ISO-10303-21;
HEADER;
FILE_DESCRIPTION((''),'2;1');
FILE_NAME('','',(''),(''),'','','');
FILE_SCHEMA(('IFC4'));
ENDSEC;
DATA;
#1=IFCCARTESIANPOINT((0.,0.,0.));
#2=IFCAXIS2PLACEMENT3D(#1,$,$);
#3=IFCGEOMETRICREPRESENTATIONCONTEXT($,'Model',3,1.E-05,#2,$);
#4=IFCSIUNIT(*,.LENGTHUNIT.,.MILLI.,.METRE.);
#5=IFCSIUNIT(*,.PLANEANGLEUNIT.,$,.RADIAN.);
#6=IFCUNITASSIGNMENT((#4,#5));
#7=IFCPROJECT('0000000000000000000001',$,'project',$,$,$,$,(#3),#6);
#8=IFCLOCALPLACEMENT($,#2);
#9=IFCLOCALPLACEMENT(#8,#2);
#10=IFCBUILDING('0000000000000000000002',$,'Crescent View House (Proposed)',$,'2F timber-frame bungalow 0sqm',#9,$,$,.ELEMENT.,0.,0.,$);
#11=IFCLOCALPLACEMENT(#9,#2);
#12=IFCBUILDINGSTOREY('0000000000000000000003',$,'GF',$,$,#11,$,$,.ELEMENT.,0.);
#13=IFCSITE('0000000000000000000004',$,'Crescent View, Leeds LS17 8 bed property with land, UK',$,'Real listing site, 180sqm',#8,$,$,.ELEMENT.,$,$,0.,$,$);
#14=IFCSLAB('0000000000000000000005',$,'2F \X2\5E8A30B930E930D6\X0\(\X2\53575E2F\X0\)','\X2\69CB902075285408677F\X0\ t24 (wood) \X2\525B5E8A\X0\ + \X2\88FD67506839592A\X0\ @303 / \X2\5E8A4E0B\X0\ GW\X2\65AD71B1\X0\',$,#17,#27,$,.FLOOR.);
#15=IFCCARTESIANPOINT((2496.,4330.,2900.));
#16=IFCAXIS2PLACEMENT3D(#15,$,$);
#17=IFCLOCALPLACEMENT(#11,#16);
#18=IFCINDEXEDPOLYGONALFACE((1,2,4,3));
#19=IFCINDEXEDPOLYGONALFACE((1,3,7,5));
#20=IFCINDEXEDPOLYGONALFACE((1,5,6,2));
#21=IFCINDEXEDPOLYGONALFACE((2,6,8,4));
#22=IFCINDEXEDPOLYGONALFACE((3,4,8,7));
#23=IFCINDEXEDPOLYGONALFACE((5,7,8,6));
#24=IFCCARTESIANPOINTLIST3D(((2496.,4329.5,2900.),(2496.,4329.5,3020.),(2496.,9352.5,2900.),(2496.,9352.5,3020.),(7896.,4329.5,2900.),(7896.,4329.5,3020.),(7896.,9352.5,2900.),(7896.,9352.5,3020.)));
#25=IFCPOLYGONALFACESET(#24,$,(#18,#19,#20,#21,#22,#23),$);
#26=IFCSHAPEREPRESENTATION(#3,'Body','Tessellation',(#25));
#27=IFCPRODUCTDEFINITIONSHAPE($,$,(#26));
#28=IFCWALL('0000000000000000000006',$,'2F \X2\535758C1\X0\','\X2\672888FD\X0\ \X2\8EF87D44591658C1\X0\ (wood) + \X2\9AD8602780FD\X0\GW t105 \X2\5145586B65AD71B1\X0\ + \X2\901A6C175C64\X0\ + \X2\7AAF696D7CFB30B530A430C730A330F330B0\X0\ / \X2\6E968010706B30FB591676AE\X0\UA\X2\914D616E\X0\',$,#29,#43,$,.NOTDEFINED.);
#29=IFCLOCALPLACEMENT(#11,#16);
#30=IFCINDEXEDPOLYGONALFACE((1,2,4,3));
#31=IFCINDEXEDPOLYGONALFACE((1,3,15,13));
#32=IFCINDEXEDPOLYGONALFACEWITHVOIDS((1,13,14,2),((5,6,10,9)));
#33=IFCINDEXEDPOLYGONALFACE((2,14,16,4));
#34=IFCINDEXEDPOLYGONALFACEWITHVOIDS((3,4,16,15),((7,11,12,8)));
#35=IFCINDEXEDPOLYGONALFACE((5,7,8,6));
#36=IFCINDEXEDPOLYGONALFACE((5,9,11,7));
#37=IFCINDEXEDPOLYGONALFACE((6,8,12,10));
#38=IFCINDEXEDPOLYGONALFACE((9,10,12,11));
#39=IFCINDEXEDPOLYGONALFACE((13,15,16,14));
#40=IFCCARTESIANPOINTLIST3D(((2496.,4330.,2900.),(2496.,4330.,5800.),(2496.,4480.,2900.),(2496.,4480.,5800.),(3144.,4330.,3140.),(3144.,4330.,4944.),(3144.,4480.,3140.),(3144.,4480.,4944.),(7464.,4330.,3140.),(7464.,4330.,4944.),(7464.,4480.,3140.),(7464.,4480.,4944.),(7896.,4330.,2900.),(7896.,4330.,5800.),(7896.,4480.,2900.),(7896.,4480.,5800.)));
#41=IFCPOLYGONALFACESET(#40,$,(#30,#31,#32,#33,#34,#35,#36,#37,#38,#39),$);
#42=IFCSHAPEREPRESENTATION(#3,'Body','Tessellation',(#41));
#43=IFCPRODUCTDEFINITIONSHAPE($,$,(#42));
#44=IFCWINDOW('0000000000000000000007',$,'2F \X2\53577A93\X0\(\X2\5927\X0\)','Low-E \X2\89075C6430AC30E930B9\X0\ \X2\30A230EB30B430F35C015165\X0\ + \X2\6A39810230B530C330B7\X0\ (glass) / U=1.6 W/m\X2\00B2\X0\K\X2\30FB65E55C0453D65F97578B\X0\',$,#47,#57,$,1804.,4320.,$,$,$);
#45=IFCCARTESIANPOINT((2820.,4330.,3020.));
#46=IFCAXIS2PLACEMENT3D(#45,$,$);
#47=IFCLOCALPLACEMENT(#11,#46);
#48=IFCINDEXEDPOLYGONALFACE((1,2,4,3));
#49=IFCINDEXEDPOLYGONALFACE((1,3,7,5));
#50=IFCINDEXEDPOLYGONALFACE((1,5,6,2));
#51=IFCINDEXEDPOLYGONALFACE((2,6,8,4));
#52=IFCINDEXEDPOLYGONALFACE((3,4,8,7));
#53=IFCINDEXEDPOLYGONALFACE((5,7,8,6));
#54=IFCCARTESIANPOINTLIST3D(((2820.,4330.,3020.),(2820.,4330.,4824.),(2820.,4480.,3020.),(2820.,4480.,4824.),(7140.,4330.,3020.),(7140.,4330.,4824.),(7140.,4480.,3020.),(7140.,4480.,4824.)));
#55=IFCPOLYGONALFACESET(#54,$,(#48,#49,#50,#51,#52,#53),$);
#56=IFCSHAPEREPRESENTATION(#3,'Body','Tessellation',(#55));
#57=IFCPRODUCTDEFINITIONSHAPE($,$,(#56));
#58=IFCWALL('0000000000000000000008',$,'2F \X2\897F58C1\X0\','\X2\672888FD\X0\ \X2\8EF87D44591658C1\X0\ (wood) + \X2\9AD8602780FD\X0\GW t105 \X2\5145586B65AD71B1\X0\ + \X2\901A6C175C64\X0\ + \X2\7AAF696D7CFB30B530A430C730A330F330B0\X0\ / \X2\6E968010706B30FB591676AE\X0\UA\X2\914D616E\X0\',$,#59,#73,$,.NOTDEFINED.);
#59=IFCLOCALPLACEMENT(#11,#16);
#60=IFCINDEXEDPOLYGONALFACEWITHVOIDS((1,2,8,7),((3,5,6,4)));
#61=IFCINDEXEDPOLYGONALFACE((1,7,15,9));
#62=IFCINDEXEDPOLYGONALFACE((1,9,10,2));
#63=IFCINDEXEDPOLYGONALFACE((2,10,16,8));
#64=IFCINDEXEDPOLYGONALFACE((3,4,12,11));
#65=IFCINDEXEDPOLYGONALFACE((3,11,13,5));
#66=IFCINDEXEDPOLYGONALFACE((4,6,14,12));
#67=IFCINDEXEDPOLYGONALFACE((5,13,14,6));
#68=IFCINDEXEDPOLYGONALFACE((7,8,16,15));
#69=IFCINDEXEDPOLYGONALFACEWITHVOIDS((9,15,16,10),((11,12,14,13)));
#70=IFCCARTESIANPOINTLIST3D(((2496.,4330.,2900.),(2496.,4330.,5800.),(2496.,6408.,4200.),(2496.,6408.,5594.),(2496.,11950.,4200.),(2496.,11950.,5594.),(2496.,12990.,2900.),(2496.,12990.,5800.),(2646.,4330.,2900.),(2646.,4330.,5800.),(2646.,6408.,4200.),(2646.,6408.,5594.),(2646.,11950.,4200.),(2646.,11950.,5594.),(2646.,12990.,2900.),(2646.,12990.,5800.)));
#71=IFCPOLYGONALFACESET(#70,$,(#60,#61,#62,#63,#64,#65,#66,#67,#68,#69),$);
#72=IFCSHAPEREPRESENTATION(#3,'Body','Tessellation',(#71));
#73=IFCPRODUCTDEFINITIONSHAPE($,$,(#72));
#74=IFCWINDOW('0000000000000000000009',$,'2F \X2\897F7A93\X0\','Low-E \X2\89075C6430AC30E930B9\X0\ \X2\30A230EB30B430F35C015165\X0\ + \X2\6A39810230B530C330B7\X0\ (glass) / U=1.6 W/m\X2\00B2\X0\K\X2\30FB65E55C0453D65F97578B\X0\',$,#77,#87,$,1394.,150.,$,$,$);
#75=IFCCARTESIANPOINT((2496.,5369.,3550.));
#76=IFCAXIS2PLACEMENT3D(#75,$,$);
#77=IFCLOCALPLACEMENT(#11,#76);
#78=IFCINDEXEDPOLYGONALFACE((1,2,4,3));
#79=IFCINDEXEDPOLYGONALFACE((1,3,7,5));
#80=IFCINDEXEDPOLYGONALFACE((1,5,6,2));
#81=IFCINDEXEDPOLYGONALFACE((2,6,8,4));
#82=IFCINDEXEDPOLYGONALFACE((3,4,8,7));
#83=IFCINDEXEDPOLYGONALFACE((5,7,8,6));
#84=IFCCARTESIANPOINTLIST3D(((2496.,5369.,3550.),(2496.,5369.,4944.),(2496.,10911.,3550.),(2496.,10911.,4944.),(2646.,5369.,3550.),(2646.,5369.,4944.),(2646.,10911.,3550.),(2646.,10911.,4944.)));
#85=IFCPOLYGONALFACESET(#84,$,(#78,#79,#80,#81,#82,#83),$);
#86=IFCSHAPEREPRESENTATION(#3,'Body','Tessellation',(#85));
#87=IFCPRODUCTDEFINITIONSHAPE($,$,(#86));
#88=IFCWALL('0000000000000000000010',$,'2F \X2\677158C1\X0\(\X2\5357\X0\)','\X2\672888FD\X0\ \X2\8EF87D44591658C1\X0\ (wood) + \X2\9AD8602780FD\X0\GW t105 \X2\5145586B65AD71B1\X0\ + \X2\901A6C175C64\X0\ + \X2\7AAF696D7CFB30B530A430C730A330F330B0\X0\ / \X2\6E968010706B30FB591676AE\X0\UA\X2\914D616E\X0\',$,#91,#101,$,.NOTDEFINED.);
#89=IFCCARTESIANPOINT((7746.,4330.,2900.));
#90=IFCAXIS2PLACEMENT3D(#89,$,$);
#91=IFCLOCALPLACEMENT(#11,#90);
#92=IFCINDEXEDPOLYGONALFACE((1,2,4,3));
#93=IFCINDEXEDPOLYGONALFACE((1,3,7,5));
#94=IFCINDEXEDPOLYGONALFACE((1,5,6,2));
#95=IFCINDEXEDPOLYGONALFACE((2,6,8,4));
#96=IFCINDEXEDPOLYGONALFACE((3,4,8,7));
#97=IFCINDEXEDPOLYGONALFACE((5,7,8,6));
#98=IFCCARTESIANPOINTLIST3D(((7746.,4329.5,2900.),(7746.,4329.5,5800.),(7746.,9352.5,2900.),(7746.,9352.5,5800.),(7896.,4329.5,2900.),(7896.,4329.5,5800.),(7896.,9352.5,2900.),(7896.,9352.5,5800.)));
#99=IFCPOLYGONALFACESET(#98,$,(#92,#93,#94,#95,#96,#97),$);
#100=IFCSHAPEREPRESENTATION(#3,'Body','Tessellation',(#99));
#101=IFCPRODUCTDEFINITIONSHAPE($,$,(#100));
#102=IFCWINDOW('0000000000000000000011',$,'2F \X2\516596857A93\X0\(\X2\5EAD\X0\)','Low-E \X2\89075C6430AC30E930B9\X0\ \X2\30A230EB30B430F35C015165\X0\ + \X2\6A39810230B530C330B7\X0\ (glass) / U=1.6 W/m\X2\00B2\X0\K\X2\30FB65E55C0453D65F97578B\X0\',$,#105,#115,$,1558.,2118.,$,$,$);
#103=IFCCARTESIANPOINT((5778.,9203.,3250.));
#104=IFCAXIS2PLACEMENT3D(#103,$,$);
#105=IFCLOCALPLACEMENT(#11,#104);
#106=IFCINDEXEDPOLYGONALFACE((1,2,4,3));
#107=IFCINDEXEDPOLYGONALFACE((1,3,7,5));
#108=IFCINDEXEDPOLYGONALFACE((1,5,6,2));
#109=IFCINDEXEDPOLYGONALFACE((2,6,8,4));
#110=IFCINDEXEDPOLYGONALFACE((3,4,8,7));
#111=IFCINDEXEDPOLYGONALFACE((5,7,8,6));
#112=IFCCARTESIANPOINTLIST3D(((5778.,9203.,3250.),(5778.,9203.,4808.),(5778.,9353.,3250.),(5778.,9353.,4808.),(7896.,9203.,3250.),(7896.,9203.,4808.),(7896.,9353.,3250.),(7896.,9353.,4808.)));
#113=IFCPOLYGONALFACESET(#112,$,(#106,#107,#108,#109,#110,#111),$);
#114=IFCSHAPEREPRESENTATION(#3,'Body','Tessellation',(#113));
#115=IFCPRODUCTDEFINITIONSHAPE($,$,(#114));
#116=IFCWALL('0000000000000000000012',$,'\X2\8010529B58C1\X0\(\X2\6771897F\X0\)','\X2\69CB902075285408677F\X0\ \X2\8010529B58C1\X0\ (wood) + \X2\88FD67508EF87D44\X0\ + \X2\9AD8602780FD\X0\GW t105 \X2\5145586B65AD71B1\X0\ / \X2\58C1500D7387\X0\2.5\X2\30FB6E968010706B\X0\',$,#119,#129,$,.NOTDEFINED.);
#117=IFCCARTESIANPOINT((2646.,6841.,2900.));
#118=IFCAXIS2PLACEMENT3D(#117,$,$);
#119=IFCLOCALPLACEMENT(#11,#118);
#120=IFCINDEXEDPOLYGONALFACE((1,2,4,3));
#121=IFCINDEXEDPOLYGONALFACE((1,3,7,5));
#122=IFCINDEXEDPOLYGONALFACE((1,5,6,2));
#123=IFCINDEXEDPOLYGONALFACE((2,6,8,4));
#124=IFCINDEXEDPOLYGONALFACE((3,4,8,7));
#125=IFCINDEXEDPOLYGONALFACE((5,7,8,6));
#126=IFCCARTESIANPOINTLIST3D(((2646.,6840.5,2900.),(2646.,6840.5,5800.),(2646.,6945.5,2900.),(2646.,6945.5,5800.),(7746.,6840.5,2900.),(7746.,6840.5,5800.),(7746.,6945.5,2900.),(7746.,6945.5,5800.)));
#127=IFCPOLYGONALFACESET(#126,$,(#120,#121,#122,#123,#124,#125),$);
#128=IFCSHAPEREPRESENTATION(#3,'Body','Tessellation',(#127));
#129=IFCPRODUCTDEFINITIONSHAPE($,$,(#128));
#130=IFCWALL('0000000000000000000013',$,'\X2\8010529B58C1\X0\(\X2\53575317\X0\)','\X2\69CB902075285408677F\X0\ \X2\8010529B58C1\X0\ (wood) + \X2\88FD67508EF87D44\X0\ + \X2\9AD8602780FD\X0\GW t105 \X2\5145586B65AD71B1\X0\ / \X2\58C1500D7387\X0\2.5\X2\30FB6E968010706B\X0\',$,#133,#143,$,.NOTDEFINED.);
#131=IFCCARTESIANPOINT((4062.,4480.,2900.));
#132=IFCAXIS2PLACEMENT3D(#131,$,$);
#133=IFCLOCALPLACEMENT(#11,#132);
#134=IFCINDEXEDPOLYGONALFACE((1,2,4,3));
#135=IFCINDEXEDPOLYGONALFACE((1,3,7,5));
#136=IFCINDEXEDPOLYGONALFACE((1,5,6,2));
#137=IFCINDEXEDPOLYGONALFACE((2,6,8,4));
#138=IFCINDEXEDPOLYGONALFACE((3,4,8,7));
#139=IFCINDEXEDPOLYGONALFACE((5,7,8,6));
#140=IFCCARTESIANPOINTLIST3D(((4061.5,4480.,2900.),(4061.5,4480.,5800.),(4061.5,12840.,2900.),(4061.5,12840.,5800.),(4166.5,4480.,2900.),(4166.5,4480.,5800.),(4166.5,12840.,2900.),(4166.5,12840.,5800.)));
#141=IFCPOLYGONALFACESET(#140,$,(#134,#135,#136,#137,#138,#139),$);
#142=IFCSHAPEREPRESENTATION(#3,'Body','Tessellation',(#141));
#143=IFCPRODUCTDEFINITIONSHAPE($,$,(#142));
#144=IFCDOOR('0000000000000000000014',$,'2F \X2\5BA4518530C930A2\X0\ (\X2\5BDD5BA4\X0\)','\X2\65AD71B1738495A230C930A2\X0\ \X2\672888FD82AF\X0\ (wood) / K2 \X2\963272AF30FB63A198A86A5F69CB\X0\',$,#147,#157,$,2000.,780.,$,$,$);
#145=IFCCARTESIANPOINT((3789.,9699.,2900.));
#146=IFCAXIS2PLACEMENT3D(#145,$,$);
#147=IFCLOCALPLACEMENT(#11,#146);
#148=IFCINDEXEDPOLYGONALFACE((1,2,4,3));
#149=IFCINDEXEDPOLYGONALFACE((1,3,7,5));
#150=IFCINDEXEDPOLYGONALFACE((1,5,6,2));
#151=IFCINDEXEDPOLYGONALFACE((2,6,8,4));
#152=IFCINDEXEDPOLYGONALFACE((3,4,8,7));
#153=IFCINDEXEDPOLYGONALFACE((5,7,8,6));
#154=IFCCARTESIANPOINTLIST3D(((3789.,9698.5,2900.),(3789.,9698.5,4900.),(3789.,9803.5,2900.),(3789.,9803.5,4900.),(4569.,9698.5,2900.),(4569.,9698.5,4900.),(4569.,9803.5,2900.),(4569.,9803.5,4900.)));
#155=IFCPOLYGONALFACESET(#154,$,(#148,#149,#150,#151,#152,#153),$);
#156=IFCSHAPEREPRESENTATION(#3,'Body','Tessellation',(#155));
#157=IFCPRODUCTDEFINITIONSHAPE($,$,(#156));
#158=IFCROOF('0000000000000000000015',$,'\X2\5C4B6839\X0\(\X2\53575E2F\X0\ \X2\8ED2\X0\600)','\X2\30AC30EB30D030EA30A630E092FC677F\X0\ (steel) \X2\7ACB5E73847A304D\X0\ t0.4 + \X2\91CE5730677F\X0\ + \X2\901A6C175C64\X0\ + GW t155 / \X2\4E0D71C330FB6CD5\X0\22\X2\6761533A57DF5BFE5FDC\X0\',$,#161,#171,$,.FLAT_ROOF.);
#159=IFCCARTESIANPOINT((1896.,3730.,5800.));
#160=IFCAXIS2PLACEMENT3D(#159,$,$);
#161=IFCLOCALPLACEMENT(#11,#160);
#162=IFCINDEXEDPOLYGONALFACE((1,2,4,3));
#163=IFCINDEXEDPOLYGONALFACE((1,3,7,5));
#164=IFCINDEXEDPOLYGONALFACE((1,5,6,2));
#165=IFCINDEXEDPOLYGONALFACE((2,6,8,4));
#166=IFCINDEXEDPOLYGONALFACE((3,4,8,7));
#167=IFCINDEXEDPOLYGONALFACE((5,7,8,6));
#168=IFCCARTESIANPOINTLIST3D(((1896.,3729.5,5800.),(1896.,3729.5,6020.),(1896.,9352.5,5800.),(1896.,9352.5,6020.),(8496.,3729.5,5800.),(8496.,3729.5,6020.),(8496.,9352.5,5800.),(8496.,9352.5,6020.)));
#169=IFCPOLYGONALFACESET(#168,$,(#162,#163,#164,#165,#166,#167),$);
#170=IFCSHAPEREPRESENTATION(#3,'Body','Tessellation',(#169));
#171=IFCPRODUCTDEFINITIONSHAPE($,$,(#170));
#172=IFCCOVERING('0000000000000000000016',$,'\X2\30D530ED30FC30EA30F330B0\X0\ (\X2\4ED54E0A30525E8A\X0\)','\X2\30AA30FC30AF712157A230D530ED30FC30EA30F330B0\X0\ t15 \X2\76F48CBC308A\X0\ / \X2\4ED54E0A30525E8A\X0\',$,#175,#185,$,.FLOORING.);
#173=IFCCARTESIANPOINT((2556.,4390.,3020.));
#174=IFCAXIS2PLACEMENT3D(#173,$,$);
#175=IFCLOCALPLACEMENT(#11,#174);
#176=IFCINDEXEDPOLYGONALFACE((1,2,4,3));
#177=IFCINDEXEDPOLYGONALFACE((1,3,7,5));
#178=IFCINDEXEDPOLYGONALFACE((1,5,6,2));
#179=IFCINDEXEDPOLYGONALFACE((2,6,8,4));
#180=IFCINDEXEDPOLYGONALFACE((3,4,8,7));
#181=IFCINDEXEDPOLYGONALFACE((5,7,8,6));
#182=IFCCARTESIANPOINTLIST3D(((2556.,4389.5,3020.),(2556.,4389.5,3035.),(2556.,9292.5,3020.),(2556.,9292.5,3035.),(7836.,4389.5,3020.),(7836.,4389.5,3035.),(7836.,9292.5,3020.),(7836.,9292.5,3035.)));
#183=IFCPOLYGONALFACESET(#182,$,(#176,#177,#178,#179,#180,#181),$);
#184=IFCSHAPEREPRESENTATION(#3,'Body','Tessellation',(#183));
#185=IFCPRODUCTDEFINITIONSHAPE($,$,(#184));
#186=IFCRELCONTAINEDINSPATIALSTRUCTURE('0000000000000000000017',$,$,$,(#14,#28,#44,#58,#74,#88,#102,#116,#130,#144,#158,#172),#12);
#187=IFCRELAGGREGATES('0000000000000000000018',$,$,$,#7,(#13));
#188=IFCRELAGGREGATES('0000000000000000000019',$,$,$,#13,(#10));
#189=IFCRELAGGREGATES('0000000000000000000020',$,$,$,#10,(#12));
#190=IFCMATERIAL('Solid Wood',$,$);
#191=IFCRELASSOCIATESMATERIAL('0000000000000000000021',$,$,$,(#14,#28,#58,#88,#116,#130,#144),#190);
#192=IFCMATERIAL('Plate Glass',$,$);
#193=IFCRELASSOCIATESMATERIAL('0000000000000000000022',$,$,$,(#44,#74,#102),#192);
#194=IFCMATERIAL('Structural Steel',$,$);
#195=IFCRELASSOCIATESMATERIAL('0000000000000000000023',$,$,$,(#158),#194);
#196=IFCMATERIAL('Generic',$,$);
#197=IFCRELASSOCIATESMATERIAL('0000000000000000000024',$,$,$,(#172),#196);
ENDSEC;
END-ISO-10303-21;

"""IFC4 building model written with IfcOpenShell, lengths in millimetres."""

from ifc_helpers import new_model, si_unit, frame, frame_2d, origin, place, context, project, spatial, rectangle, extrude, material, element, fill, save


model = new_model("IFC4")

# Units and contexts
model_context = context("Model", 3, precision=1e-05, world=origin())
ifc_project = project(units=[si_unit("LENGTHUNIT", "METRE", prefix="MILLI"), si_unit("PLANEANGLEUNIT", "RADIAN")], contexts=[model_context])

# Site, building, storey
site_placement = place(None, origin())
site = spatial("IfcSite", under=ifc_project, at=site_placement, Name="Crescent View, Leeds LS17 8 bed property with land, UK", ObjectType="Real listing site, 180sqm", CompositionType="ELEMENT", RefElevation=0.0)
building_placement = place(site_placement, origin())
building = spatial("IfcBuilding", under=site, at=building_placement, Name="Crescent View House (Proposed)", ObjectType="2F timber-frame bungalow 0sqm", CompositionType="ELEMENT", ElevationOfRefHeight=0.0, ElevationOfTerrain=0.0)
storey_placement = place(building_placement, origin())
storey = spatial("IfcBuildingStorey", under=building, at=storey_placement, Name="GF", CompositionType="ELEMENT", Elevation=0.0)

# Slab
ifc_material_1 = material(Name="Solid Wood")
slab_placement = place(storey_placement, frame((2496.0, 4330.0, 2900.0)))
element("IfcSlab", 1, at=slab_placement, inside=storey, material=ifc_material_1, Name="2F 床スラブ(南帯)", Description="構造用合板 t24 (wood) 剛床 + 製材根太 @303 / 床下 GW断熱", PredefinedType="FLOOR", context=model_context, shape_type="SweptSolid", body=[
    extrude(rectangle(XDim=5400.0, YDim=5023.0, at=frame_2d((2700.0, 2511.0))), frame((2496.0, 4330.0, 2900.0)), (0.0, 0.0, 1.0), 120.0),
])

# Walls, openings, windows
wall_1_placement = place(storey_placement, frame((2496.0, 4330.0, 2900.0)))
wall_1 = element("IfcWall", 2, at=wall_1_placement, inside=storey, material=ifc_material_1, Name="2F 南壁", Description="木製 軸組外壁 (wood) + 高性能GW t105 充填断熱 + 通気層 + 窯業系サイディング / 準耐火・外皮UA配慮", PredefinedType="NOTDEFINED", context=model_context, shape_type="SweptSolid", body=[
    extrude(rectangle(XDim=5400.0, YDim=150.0, at=frame_2d((2700.0, 75.0))), frame((2496.0, 4330.0, 2900.0)), (0.0, 0.0, 1.0), 2900.0),
])
opening_1_placement = place(storey_placement, frame((2820.0, 4330.0, 3020.0)))
opening_1 = element("IfcOpeningElement", 3, at=opening_1_placement, cuts=wall_1, PredefinedType="NOTDEFINED", context=model_context, shape_type="SweptSolid", body=[
    extrude(rectangle(XDim=4320.0, YDim=150.0, at=frame_2d((2160.0, 75.0))), frame((2820.0, 4330.0, 3020.0)), (0.0, 0.0, 1.0), 1804.0),
])
ifc_material_2 = material(Name="Plate Glass")
window_1_placement = place(storey_placement, frame((2820.0, 4330.0, 3020.0)))
window_1 = element("IfcWindow", 4, at=window_1_placement, inside=storey, material=ifc_material_2, Name="2F 南窓(大)", Description="Low-E 複層ガラス アルゴン封入 + 樹脂サッシ (glass) / U=1.6 W/m²K・日射取得型", OverallHeight=1804.0, OverallWidth=4320.0, context=model_context, shape_type="SweptSolid", body=[
    extrude(rectangle(XDim=4320.0, YDim=150.0, at=frame_2d((2160.0, 75.0))), frame((2820.0, 4330.0, 3020.0)), (0.0, 0.0, 1.0), 1804.0),
])
fill(opening_1, window_1)
wall_2_placement = place(storey_placement, frame((2496.0, 4330.0, 2900.0)))
wall_2 = element("IfcWall", 5, at=wall_2_placement, inside=storey, material=ifc_material_1, Name="2F 西壁", Description="木製 軸組外壁 (wood) + 高性能GW t105 充填断熱 + 通気層 + 窯業系サイディング / 準耐火・外皮UA配慮", PredefinedType="NOTDEFINED", context=model_context, shape_type="SweptSolid", body=[
    extrude(rectangle(XDim=150.0, YDim=8660.0, at=frame_2d((75.0, 4330.0))), frame((2496.0, 4330.0, 2900.0)), (0.0, 0.0, 1.0), 2900.0),
])
opening_2_placement = place(storey_placement, frame((2496.0, 5369.0, 3550.0)))
opening_2 = element("IfcOpeningElement", 6, at=opening_2_placement, cuts=wall_2, PredefinedType="NOTDEFINED", context=model_context, shape_type="SweptSolid", body=[
    extrude(rectangle(XDim=150.0, YDim=5542.0, at=frame_2d((75.0, 2771.0))), frame((2496.0, 5369.0, 3550.0)), (0.0, 0.0, 1.0), 1394.0),
])
window_2_placement = place(storey_placement, frame((2496.0, 5369.0, 3550.0)))
window_2 = element("IfcWindow", 7, at=window_2_placement, inside=storey, material=ifc_material_2, Name="2F 西窓", Description="Low-E 複層ガラス アルゴン封入 + 樹脂サッシ (glass) / U=1.6 W/m²K・日射取得型", OverallHeight=1394.0, OverallWidth=150.0, context=model_context, shape_type="SweptSolid", body=[
    extrude(rectangle(XDim=150.0, YDim=5542.0, at=frame_2d((75.0, 2771.0))), frame((2496.0, 5369.0, 3550.0)), (0.0, 0.0, 1.0), 1394.0),
])
fill(opening_2, window_2)
wall_3_placement = place(storey_placement, frame((7746.0, 4330.0, 2900.0)))
wall_3 = element("IfcWall", 8, at=wall_3_placement, inside=storey, material=ifc_material_1, Name="2F 東壁(南)", Description="木製 軸組外壁 (wood) + 高性能GW t105 充填断熱 + 通気層 + 窯業系サイディング / 準耐火・外皮UA配慮", PredefinedType="NOTDEFINED", context=model_context, shape_type="SweptSolid", body=[
    extrude(rectangle(XDim=150.0, YDim=5023.0, at=frame_2d((75.0, 2511.0))), frame((7746.0, 4330.0, 2900.0)), (0.0, 0.0, 1.0), 2900.0),
])
opening_3_placement = place(storey_placement, frame((5778.0, 9203.0, 3250.0)))
opening_3 = element("IfcOpeningElement", 9, at=opening_3_placement, cuts=wall_3, PredefinedType="NOTDEFINED", context=model_context, shape_type="SweptSolid", body=[
    extrude(rectangle(XDim=2118.0, YDim=150.0, at=frame_2d((1059.0, 75.0))), frame((5778.0, 9203.0, 3250.0)), (0.0, 0.0, 1.0), 1558.0),
])
window_3_placement = place(storey_placement, frame((5778.0, 9203.0, 3250.0)))
window_3 = element("IfcWindow", 10, at=window_3_placement, inside=storey, material=ifc_material_2, Name="2F 入隅窓(庭)", Description="Low-E 複層ガラス アルゴン封入 + 樹脂サッシ (glass) / U=1.6 W/m²K・日射取得型", OverallHeight=1558.0, OverallWidth=2118.0, context=model_context, shape_type="SweptSolid", body=[
    extrude(rectangle(XDim=2118.0, YDim=150.0, at=frame_2d((1059.0, 75.0))), frame((5778.0, 9203.0, 3250.0)), (0.0, 0.0, 1.0), 1558.0),
])
fill(opening_3, window_3)

# Wall
wall_4_placement = place(storey_placement, frame((2646.0, 6841.0, 2900.0)))
element("IfcWall", 11, at=wall_4_placement, inside=storey, material=ifc_material_1, Name="耐力壁(東西)", Description="構造用合板 耐力壁 (wood) + 製材軸組 + 高性能GW t105 充填断熱 / 壁倍率2.5・準耐火", PredefinedType="NOTDEFINED", context=model_context, shape_type="SweptSolid", body=[
    extrude(rectangle(XDim=5100.0, YDim=105.0, at=frame_2d((2550.0, 52.0))), frame((2646.0, 6841.0, 2900.0)), (0.0, 0.0, 1.0), 2900.0),
])

# Wall, opening, door
wall_5_placement = place(storey_placement, frame((4062.0, 4480.0, 2900.0)))
wall_5 = element("IfcWall", 12, at=wall_5_placement, inside=storey, material=ifc_material_1, Name="耐力壁(南北)", Description="構造用合板 耐力壁 (wood) + 製材軸組 + 高性能GW t105 充填断熱 / 壁倍率2.5・準耐火", PredefinedType="NOTDEFINED", context=model_context, shape_type="SweptSolid", body=[
    extrude(rectangle(XDim=105.0, YDim=8360.0, at=frame_2d((52.0, 4180.0))), frame((4062.0, 4480.0, 2900.0)), (0.0, 0.0, 1.0), 2900.0),
])
opening_4_placement = place(storey_placement, frame((3789.0, 9699.0, 2900.0)))
opening_4 = element("IfcOpeningElement", 13, at=opening_4_placement, cuts=wall_5, PredefinedType="NOTDEFINED", context=model_context, shape_type="SweptSolid", body=[
    extrude(rectangle(XDim=780.0, YDim=105.0, at=frame_2d((390.0, 52.0))), frame((3789.0, 9699.0, 2900.0)), (0.0, 0.0, 1.0), 2000.0),
])
door_placement = place(storey_placement, frame((3789.0, 9699.0, 2900.0)))
door = element("IfcDoor", 14, at=door_placement, inside=storey, material=ifc_material_1, Name="2F 室内ドア (寝室)", Description="断熱玄関ドア 木製芯 (wood) / K2 防犯・採風機構", OverallHeight=2000.0, OverallWidth=780.0, context=model_context, shape_type="SweptSolid", body=[
    extrude(rectangle(XDim=780.0, YDim=105.0, at=frame_2d((390.0, 52.0))), frame((3789.0, 9699.0, 2900.0)), (0.0, 0.0, 1.0), 2000.0),
])
fill(opening_4, door)

# Roof
ifc_material_3 = material(Name="Structural Steel")
for number, where, name in (
    (15, (1896.0, 3730.0, 5800.0), "屋根(南帯 軒600)"),
):
    element("IfcRoof", number, at=place(storey_placement, frame(where)), inside=storey, material=ifc_material_3, Name=name, Description="ガルバリウム鋼板 (steel) 立平葺き t0.4 + 野地板 + 通気層 + GW t155 / 不燃・法22条区域対応", PredefinedType="FLAT_ROOF", context=model_context, shape_type="SweptSolid", body=[
        extrude(rectangle(XDim=6600.0, YDim=5623.0, at=frame_2d((3300.0, 2811.0))), frame((1896.0, 3730.0, 5800.0)), (0.0, 0.0, 1.0), 220.0),
    ])

# Covering
ifc_material_4 = material(Name="Generic")
covering_placement = place(storey_placement, frame((2556.0, 4390.0, 3020.0)))
element("IfcCovering", 16, at=covering_placement, inside=storey, material=ifc_material_4, Name="フローリング (仕上げ床)", Description="オーク無垢フローリング t15 直貼り / 仕上げ床", PredefinedType="FLOORING", context=model_context, shape_type="SweptSolid", body=[
    extrude(rectangle(XDim=5280.0, YDim=4903.0, at=frame_2d((2640.0, 2451.0))), frame((2556.0, 4390.0, 3020.0)), (0.0, 0.0, 1.0), 15.0),
])

save(model, "model.ifc")
